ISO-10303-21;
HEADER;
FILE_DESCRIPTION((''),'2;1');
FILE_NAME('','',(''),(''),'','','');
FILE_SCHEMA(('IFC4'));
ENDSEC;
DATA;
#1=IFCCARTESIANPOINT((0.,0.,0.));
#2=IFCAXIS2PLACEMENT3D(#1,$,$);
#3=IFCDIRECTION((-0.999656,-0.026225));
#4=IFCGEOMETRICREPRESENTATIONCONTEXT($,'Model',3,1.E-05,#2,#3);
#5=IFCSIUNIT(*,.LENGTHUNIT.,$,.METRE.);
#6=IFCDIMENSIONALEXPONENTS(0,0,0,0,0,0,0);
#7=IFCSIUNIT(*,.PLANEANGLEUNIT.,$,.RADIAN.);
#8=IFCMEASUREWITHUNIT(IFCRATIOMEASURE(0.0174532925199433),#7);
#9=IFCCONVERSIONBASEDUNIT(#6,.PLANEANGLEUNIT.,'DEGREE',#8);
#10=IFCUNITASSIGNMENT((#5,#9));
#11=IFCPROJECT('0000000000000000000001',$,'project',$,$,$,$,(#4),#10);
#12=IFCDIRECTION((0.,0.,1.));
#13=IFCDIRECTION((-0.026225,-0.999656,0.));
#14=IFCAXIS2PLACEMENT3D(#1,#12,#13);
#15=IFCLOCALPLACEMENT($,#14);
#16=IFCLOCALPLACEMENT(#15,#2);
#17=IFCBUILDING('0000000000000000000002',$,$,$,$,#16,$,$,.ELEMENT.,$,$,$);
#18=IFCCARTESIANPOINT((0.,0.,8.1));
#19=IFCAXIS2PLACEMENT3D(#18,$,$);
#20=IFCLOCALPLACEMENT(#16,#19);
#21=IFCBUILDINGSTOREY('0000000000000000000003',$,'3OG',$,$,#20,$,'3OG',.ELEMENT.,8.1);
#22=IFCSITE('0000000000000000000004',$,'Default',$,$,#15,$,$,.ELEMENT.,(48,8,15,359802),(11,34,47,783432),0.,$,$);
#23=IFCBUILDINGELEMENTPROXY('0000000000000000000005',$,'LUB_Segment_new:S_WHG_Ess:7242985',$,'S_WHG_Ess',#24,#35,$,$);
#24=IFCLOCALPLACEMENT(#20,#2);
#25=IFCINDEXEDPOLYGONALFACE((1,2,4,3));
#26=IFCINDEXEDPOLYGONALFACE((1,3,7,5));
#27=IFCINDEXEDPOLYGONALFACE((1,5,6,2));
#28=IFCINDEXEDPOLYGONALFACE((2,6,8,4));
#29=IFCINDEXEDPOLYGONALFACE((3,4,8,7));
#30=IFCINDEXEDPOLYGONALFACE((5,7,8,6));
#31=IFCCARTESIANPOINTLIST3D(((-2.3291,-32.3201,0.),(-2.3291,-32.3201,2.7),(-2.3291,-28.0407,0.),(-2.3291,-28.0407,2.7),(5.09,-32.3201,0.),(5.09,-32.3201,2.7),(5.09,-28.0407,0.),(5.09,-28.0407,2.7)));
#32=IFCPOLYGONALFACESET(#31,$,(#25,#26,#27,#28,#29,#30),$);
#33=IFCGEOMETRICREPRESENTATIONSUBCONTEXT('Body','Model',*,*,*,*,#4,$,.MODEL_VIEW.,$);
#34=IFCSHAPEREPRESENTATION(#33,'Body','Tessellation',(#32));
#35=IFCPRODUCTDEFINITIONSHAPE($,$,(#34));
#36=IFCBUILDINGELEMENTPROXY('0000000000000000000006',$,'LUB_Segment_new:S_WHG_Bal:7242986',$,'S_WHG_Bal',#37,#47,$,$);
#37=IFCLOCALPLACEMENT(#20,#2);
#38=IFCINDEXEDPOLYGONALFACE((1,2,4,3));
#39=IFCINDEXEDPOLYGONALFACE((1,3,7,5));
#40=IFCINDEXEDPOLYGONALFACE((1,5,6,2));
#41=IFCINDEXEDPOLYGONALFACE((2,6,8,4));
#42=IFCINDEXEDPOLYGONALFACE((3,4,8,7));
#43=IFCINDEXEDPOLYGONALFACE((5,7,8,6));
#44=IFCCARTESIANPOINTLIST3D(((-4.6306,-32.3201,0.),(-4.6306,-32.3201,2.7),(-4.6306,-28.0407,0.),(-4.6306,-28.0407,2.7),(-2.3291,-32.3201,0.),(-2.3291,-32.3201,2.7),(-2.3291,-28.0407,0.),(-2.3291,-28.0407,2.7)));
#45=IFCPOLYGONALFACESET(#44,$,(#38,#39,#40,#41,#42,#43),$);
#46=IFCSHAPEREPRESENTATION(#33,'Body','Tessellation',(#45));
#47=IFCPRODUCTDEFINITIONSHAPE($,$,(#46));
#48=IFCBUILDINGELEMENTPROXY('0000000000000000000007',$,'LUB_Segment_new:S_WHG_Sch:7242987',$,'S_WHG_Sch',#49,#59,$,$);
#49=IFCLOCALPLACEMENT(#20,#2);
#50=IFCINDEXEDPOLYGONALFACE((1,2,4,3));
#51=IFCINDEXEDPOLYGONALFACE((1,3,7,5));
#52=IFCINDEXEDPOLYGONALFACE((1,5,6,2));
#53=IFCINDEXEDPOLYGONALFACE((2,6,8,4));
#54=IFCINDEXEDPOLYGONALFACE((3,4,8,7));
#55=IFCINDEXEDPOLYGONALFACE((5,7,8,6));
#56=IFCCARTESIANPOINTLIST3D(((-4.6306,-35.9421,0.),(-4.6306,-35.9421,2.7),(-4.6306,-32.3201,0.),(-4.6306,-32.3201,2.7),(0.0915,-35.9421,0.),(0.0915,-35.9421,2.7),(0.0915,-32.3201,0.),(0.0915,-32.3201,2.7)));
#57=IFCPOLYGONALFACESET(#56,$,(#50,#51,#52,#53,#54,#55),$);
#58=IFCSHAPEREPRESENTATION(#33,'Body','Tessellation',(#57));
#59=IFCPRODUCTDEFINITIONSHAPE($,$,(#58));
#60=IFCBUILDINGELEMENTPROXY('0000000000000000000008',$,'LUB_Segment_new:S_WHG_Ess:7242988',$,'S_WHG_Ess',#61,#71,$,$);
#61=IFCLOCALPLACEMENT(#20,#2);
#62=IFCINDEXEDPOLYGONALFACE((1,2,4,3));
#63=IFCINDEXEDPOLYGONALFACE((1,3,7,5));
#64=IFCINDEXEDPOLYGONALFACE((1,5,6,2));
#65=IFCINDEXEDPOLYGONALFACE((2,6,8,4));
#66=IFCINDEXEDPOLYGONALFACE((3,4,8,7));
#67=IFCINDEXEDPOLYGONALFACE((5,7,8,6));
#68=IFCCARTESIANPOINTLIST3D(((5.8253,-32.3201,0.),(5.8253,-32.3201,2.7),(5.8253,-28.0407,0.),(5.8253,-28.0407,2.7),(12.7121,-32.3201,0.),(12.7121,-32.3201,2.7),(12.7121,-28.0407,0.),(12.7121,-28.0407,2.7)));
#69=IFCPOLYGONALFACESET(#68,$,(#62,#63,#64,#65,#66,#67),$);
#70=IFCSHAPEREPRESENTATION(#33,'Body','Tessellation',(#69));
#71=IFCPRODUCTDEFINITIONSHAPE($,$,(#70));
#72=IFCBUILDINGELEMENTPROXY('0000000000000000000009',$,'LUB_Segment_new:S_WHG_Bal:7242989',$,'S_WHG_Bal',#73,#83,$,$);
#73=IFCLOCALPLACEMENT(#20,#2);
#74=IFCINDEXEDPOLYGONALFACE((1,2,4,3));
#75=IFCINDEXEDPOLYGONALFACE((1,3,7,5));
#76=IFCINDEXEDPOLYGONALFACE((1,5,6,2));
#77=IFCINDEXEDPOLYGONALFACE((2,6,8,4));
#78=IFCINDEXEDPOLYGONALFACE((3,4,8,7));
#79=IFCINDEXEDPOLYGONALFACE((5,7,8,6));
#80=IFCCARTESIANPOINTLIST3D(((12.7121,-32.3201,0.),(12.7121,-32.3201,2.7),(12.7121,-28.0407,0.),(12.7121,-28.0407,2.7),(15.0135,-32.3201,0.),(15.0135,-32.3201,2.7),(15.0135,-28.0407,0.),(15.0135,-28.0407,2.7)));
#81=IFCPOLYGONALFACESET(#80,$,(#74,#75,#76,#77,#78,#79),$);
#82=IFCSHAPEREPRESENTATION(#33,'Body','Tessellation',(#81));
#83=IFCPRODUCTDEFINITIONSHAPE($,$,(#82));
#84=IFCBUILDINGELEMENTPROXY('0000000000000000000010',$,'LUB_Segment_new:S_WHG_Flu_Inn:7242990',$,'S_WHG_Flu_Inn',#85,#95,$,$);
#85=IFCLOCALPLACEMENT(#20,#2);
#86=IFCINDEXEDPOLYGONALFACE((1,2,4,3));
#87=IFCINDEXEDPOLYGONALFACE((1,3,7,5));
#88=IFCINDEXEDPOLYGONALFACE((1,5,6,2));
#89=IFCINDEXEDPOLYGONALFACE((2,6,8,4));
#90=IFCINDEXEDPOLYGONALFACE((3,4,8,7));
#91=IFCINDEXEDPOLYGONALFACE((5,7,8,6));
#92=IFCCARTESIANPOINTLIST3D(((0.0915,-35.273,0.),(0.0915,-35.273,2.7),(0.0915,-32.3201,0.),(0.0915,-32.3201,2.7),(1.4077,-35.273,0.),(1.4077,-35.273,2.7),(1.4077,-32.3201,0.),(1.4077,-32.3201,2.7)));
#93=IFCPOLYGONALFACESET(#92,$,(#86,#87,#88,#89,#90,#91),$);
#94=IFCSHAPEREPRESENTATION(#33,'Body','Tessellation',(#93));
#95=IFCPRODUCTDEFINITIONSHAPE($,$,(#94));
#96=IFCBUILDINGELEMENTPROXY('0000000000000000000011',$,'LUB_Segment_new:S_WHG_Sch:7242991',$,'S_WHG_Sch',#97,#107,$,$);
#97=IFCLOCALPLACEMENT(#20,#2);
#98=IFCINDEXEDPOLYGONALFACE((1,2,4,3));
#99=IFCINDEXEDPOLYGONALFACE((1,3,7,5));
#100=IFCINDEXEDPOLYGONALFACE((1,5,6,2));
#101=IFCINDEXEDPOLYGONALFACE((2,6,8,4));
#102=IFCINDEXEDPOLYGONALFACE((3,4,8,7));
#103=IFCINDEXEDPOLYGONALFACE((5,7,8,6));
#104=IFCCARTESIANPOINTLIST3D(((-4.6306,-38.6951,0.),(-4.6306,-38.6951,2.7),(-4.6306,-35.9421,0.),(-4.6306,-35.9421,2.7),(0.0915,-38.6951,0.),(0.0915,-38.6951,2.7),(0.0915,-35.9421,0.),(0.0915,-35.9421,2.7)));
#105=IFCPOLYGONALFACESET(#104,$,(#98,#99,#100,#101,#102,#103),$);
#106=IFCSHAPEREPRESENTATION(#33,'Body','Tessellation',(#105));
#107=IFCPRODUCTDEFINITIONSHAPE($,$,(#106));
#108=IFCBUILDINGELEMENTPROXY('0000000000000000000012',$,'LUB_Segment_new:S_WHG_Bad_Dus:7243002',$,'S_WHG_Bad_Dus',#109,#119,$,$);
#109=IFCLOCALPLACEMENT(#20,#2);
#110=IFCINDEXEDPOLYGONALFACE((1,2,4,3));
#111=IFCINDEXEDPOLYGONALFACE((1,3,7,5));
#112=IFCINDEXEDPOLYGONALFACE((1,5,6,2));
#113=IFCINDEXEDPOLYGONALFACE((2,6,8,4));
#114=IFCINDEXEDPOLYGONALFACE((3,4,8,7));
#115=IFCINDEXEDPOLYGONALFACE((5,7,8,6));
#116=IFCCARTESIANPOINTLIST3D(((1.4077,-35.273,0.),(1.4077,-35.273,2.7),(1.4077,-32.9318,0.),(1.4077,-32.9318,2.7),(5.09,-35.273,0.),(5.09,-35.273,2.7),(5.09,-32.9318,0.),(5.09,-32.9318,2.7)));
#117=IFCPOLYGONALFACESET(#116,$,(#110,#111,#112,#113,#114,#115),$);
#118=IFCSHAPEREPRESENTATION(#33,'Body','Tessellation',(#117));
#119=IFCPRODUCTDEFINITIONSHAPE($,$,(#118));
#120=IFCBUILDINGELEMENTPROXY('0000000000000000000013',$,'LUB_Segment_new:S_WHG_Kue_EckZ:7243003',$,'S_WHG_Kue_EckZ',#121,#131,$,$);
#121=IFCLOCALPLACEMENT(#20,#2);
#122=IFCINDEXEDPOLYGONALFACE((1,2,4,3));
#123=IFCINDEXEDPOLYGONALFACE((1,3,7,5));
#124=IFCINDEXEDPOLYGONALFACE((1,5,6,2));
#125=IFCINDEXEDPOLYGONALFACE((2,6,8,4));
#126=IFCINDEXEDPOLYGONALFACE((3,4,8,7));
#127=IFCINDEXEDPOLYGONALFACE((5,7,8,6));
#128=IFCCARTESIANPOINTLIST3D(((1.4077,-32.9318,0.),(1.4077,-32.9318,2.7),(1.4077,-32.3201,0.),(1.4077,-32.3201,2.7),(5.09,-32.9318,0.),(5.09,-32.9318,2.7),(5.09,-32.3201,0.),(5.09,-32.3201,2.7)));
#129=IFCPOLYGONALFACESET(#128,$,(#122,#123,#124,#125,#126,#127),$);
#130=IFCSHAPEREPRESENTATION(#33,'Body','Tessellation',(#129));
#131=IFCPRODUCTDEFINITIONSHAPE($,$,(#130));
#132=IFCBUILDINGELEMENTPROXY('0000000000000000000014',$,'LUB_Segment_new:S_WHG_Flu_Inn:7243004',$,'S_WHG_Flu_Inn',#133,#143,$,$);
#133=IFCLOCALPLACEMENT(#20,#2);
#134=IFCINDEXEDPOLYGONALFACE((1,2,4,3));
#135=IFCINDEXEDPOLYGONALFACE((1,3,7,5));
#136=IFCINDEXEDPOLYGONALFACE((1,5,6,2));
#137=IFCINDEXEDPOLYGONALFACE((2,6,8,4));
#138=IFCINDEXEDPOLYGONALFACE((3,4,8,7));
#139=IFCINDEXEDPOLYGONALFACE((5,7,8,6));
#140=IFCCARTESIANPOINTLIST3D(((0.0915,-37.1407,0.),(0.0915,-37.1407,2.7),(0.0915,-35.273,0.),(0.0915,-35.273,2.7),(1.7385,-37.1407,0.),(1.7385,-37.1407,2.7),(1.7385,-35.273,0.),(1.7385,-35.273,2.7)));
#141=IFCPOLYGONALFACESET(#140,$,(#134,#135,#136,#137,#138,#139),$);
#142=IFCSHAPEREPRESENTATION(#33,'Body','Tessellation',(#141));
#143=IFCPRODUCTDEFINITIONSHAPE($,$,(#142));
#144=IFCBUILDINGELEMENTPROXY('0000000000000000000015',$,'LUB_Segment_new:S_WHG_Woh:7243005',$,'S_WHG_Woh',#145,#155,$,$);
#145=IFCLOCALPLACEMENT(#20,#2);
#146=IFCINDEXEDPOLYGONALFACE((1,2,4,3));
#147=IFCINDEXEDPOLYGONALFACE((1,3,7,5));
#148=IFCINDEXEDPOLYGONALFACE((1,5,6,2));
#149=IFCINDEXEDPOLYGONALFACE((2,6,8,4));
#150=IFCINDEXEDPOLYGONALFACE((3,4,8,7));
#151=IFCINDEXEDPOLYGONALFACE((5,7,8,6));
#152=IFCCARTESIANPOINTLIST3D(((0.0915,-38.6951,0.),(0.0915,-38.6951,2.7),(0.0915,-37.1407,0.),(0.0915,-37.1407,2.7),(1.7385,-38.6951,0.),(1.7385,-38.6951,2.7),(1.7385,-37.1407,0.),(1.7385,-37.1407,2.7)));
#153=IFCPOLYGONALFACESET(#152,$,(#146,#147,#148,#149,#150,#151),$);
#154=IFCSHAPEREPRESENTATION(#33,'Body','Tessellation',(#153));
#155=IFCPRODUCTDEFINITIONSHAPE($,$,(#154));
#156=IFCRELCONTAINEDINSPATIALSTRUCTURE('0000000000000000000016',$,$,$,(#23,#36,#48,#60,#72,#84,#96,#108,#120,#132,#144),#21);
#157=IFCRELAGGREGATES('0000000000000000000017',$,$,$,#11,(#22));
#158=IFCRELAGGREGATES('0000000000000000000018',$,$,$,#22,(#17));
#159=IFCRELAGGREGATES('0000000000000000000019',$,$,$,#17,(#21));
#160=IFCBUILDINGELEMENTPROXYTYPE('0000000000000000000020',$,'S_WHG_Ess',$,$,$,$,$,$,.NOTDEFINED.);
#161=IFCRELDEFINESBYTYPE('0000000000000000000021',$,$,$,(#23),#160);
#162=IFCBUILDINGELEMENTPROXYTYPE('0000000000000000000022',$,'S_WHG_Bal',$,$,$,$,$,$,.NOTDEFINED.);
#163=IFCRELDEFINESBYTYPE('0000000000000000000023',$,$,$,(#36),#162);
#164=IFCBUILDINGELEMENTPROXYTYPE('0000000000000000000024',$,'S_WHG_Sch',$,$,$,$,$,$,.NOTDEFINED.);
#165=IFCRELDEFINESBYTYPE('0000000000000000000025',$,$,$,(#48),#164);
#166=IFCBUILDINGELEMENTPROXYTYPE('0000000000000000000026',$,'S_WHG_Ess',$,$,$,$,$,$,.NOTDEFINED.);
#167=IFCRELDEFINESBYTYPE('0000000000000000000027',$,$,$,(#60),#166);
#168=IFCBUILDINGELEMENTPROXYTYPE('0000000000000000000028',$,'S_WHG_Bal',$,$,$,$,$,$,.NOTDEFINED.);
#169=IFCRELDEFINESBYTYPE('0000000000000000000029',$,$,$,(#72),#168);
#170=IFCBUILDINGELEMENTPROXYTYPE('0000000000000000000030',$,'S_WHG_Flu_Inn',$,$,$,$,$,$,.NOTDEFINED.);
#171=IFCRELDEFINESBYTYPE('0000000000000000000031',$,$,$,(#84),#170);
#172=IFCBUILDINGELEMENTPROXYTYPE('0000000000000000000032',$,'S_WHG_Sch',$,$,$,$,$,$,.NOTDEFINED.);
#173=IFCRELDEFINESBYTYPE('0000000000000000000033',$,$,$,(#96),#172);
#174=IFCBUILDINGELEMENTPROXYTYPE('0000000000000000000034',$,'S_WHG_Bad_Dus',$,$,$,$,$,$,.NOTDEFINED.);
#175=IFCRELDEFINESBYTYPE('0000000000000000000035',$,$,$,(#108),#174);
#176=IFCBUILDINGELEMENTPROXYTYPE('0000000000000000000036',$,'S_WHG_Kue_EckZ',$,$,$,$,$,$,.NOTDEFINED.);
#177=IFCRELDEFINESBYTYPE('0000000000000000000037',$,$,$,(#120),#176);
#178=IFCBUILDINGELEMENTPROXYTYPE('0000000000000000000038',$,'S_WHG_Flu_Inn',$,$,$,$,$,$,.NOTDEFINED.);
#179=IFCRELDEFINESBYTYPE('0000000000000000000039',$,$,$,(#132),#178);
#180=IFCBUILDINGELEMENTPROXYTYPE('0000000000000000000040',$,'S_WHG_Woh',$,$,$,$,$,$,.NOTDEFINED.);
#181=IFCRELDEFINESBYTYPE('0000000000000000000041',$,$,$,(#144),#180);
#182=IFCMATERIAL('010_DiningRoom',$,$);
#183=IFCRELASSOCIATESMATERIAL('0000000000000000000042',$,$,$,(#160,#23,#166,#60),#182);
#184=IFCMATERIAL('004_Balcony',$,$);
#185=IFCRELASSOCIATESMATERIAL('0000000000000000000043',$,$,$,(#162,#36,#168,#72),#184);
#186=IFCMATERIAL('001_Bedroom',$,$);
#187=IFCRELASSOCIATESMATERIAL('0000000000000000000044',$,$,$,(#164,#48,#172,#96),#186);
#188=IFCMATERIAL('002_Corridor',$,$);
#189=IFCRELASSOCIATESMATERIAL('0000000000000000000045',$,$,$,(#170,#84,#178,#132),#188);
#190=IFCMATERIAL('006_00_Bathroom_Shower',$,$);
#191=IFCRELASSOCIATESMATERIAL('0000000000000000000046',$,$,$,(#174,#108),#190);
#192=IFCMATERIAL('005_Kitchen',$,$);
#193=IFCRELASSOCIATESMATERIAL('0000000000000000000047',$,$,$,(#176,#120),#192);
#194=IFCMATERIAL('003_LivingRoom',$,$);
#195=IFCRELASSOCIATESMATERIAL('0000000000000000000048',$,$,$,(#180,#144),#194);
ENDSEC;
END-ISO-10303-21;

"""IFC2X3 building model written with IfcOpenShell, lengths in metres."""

from ifc_helpers import new_model, entity, si_unit, converted_unit, direction, frame, origin, origin_2d_with_axis, place, context, subcontext, project, spatial, rectangle, extrude, source, transform, mapped, material, type_object, type_shapes, element, save


model = new_model("IFC2X3")

# Units and contexts
model_context = context("Model", 3, precision=1e-05, world=origin(), true_north=direction((-0.999656, -0.026225)))
body_context = subcontext(model_context, "Body", "Model", "MODEL_VIEW")
ifc_project = project(units=[si_unit("LENGTHUNIT", "METRE"), converted_unit("PLANEANGLEUNIT", "DEGREE", entity("IfcRatioMeasure", 0.0174532925199433), si_unit("PLANEANGLEUNIT", "RADIAN"), dimensions=[0, 0, 0, 0, 0, 0, 0])], contexts=[model_context])

# Site, building, storey
site_placement = place(None, frame((0.0, 0.0, 0.0), z_axis=(0.0, 0.0, 1.0), x_axis=(-0.026225, -0.999656, 0.0)))
site = spatial("IfcSite", under=ifc_project, at=site_placement, Name="Default", CompositionType="ELEMENT", RefLatitude=(48, 8, 15, 359802), RefLongitude=(11, 34, 47, 783432), RefElevation=0.0)
building_placement = place(site_placement, origin())
building = spatial("IfcBuilding", under=site, at=building_placement, CompositionType="ELEMENT")
storey_placement = place(building_placement, frame((0.0, 0.0, 8.1)))
storey = spatial("IfcBuildingStorey", under=building, at=storey_placement, Name="3OG", LongName="3OG", CompositionType="ELEMENT", Elevation=8.1)

# Building element proxies
ifc_material_1 = material(Name="010_DiningRoom")
building_element_proxy_type_1 = type_object("IfcBuildingElementProxyType", Name="S_WHG_Ess", PredefinedType="NOTDEFINED", material=ifc_material_1)
shared_shape_1 = source(origin(), body_context, "Body", "SweptSolid", [
    extrude(rectangle(XDim=7.4191, YDim=4.2794, at=origin_2d_with_axis()), frame((0.0, 0.0, 0.0), z_axis=(0.0, 0.0, 1.0), x_axis=(-1.0, 0.0, 0.0)), (0.0, 0.0, 1.0), 2.7),
])
type_shapes(building_element_proxy_type_1, [shared_shape_1])
proxy_1_placement = place(storey_placement, frame((1.3805, -30.1804, 0.0)))
element("IfcBuildingElementProxy", 1, at=proxy_1_placement, inside=storey, type_object=building_element_proxy_type_1, material=ifc_material_1, Name="LUB_Segment_new:S_WHG_Ess:7242985", ObjectType="S_WHG_Ess", context=body_context, shape_type="MappedRepresentation", body=[
    mapped(shared_shape_1, transform((0.0, 0.0, 0.0), scale=1.0)),
])
ifc_material_2 = material(Name="004_Balcony")
building_element_proxy_type_2 = type_object("IfcBuildingElementProxyType", Name="S_WHG_Bal", PredefinedType="NOTDEFINED", material=ifc_material_2)
shared_shape_2 = source(origin(), body_context, "Body", "SweptSolid", [
    extrude(rectangle(XDim=2.3015, YDim=4.2794, at=origin_2d_with_axis()), frame((0.0, 0.0, 0.0), z_axis=(0.0, 0.0, 1.0), x_axis=(-1.0, 0.0, 0.0)), (0.0, 0.0, 1.0), 2.7),
])
type_shapes(building_element_proxy_type_2, [shared_shape_2])
proxy_2_placement = place(storey_placement, frame((-3.4798, -30.1804, 0.0)))
element("IfcBuildingElementProxy", 2, at=proxy_2_placement, inside=storey, type_object=building_element_proxy_type_2, material=ifc_material_2, Name="LUB_Segment_new:S_WHG_Bal:7242986", ObjectType="S_WHG_Bal", context=body_context, shape_type="MappedRepresentation", body=[
    mapped(shared_shape_2, transform((0.0, 0.0, 0.0), scale=1.0)),
])
ifc_material_3 = material(Name="001_Bedroom")
building_element_proxy_type_3 = type_object("IfcBuildingElementProxyType", Name="S_WHG_Sch", PredefinedType="NOTDEFINED", material=ifc_material_3)
shared_shape_3 = source(origin(), body_context, "Body", "SweptSolid", [
    extrude(rectangle(XDim=4.7221, YDim=3.6221, at=origin_2d_with_axis()), frame((0.0, 0.0, 0.0), z_axis=(0.0, 0.0, 1.0), x_axis=(-1.0, 0.0, 0.0)), (0.0, 0.0, 1.0), 2.7),
])
type_shapes(building_element_proxy_type_3, [shared_shape_3])
proxy_3_placement = place(storey_placement, frame((-2.2695, -34.1311, 0.0)))
element("IfcBuildingElementProxy", 3, at=proxy_3_placement, inside=storey, type_object=building_element_proxy_type_3, material=ifc_material_3, Name="LUB_Segment_new:S_WHG_Sch:7242987", ObjectType="S_WHG_Sch", context=body_context, shape_type="MappedRepresentation", body=[
    mapped(shared_shape_3, transform((0.0, 0.0, 0.0), scale=1.0)),
])
building_element_proxy_type_4 = type_object("IfcBuildingElementProxyType", Name="S_WHG_Ess", PredefinedType="NOTDEFINED", material=ifc_material_1)
shared_shape_4 = source(origin(), body_context, "Body", "SweptSolid", [
    extrude(rectangle(XDim=6.8868, YDim=4.2794, at=origin_2d_with_axis()), frame((0.0, 0.0, 0.0), z_axis=(0.0, 0.0, 1.0), x_axis=(-1.0, 0.0, 0.0)), (0.0, 0.0, 1.0), 2.7),
])
type_shapes(building_element_proxy_type_4, [shared_shape_4])
proxy_4_placement = place(storey_placement, frame((9.2687, -30.1804, 0.0)))
element("IfcBuildingElementProxy", 4, at=proxy_4_placement, inside=storey, type_object=building_element_proxy_type_4, material=ifc_material_1, Name="LUB_Segment_new:S_WHG_Ess:7242988", ObjectType="S_WHG_Ess", context=body_context, shape_type="MappedRepresentation", body=[
    mapped(shared_shape_4, transform((0.0, 0.0, 0.0), scale=1.0)),
])
building_element_proxy_type_5 = type_object("IfcBuildingElementProxyType", Name="S_WHG_Bal", PredefinedType="NOTDEFINED", material=ifc_material_2)
shared_shape_5 = source(origin(), body_context, "Body", "SweptSolid", [
    extrude(rectangle(XDim=4.2794, YDim=2.3015, at=origin_2d_with_axis()), frame((0.0, 0.0, 0.0), z_axis=(0.0, 0.0, 1.0), x_axis=(0.0, 1.0, 0.0)), (0.0, 0.0, 1.0), 2.7),
])
type_shapes(building_element_proxy_type_5, [shared_shape_5])
proxy_5_placement = place(storey_placement, frame((13.8628, -30.1804, 0.0), z_axis=(0.0, 0.0, 1.0), x_axis=(-1.0, 0.0, 0.0)))
element("IfcBuildingElementProxy", 5, at=proxy_5_placement, inside=storey, type_object=building_element_proxy_type_5, material=ifc_material_2, Name="LUB_Segment_new:S_WHG_Bal:7242989", ObjectType="S_WHG_Bal", context=body_context, shape_type="MappedRepresentation", body=[
    mapped(shared_shape_5, transform((0.0, 0.0, 0.0), scale=1.0)),
])
ifc_material_4 = material(Name="002_Corridor")
building_element_proxy_type_6 = type_object("IfcBuildingElementProxyType", Name="S_WHG_Flu_Inn", PredefinedType="NOTDEFINED", material=ifc_material_4)
shared_shape_6 = source(origin(), body_context, "Body", "SweptSolid", [
    extrude(rectangle(XDim=1.3162, YDim=2.9529, at=origin_2d_with_axis()), frame((0.0, 0.0, 0.0), z_axis=(0.0, 0.0, 1.0), x_axis=(-1.0, 0.0, 0.0)), (0.0, 0.0, 1.0), 2.7),
])
type_shapes(building_element_proxy_type_6, [shared_shape_6])
proxy_6_placement = place(storey_placement, frame((0.7496, -33.7966, 0.0)))
element("IfcBuildingElementProxy", 6, at=proxy_6_placement, inside=storey, type_object=building_element_proxy_type_6, material=ifc_material_4, Name="LUB_Segment_new:S_WHG_Flu_Inn:7242990", ObjectType="S_WHG_Flu_Inn", context=body_context, shape_type="MappedRepresentation", body=[
    mapped(shared_shape_6, transform((0.0, 0.0, 0.0), scale=1.0)),
])
building_element_proxy_type_7 = type_object("IfcBuildingElementProxyType", Name="S_WHG_Sch", PredefinedType="NOTDEFINED", material=ifc_material_3)
shared_shape_7 = source(origin(), body_context, "Body", "SweptSolid", [
    extrude(rectangle(XDim=4.7221, YDim=2.7529, at=origin_2d_with_axis()), frame((0.0, 0.0, 0.0), z_axis=(0.0, 0.0, 1.0), x_axis=(-1.0, 0.0, 0.0)), (0.0, 0.0, 1.0), 2.7),
])
type_shapes(building_element_proxy_type_7, [shared_shape_7])
proxy_7_placement = place(storey_placement, frame((-2.2695, -37.3186, 0.0)))
element("IfcBuildingElementProxy", 7, at=proxy_7_placement, inside=storey, type_object=building_element_proxy_type_7, material=ifc_material_3, Name="LUB_Segment_new:S_WHG_Sch:7242991", ObjectType="S_WHG_Sch", context=body_context, shape_type="MappedRepresentation", body=[
    mapped(shared_shape_7, transform((0.0, 0.0, 0.0), scale=1.0)),
])
ifc_material_5 = material(Name="006_00_Bathroom_Shower")
building_element_proxy_type_8 = type_object("IfcBuildingElementProxyType", Name="S_WHG_Bad_Dus", PredefinedType="NOTDEFINED", material=ifc_material_5)
shared_shape_8 = source(origin(), body_context, "Body", "SweptSolid", [
    extrude(rectangle(XDim=2.3412, YDim=3.6824, at=origin_2d_with_axis()), frame((0.0, 0.0, 0.0), z_axis=(0.0, 0.0, 1.0), x_axis=(0.0, 1.0, 0.0)), (0.0, 0.0, 1.0), 2.7),
])
type_shapes(building_element_proxy_type_8, [shared_shape_8])
proxy_8_placement = place(storey_placement, frame((3.2488, -34.1024, 0.0)))
element("IfcBuildingElementProxy", 8, at=proxy_8_placement, inside=storey, type_object=building_element_proxy_type_8, material=ifc_material_5, Name="LUB_Segment_new:S_WHG_Bad_Dus:7243002", ObjectType="S_WHG_Bad_Dus", context=body_context, shape_type="MappedRepresentation", body=[
    mapped(shared_shape_8, transform((0.0, 0.0, 0.0), scale=1.0)),
])
ifc_material_6 = material(Name="005_Kitchen")
building_element_proxy_type_9 = type_object("IfcBuildingElementProxyType", Name="S_WHG_Kue_EckZ", PredefinedType="NOTDEFINED", material=ifc_material_6)
shared_shape_9 = source(origin(), body_context, "Body", "SweptSolid", [
    extrude(rectangle(XDim=0.6118, YDim=3.6824, at=origin_2d_with_axis()), frame((0.0, 0.0, 0.0), z_axis=(0.0, 0.0, 1.0), x_axis=(0.0, 1.0, 0.0)), (0.0, 0.0, 1.0), 2.7),
])
type_shapes(building_element_proxy_type_9, [shared_shape_9])
proxy_9_placement = place(storey_placement, frame((3.2488, -32.626, 0.0)))
element("IfcBuildingElementProxy", 9, at=proxy_9_placement, inside=storey, type_object=building_element_proxy_type_9, material=ifc_material_6, Name="LUB_Segment_new:S_WHG_Kue_EckZ:7243003", ObjectType="S_WHG_Kue_EckZ", context=body_context, shape_type="MappedRepresentation", body=[
    mapped(shared_shape_9, transform((0.0, 0.0, 0.0), scale=1.0)),
])
building_element_proxy_type_10 = type_object("IfcBuildingElementProxyType", Name="S_WHG_Flu_Inn", PredefinedType="NOTDEFINED", material=ifc_material_4)
shared_shape_10 = source(origin(), body_context, "Body", "SweptSolid", [
    extrude(rectangle(XDim=1.6471, YDim=1.8676, at=origin_2d_with_axis()), frame((0.0, 0.0, 0.0), z_axis=(0.0, 0.0, 1.0), x_axis=(-1.0, 0.0, 0.0)), (0.0, 0.0, 1.0), 2.7),
])
type_shapes(building_element_proxy_type_10, [shared_shape_10])
proxy_10_placement = place(storey_placement, frame((0.915, -36.2068, 0.0)))
element("IfcBuildingElementProxy", 10, at=proxy_10_placement, inside=storey, type_object=building_element_proxy_type_10, material=ifc_material_4, Name="LUB_Segment_new:S_WHG_Flu_Inn:7243004", ObjectType="S_WHG_Flu_Inn", context=body_context, shape_type="MappedRepresentation", body=[
    mapped(shared_shape_10, transform((0.0, 0.0, 0.0), scale=1.0)),
])
ifc_material_7 = material(Name="003_LivingRoom")
building_element_proxy_type_11 = type_object("IfcBuildingElementProxyType", Name="S_WHG_Woh", PredefinedType="NOTDEFINED", material=ifc_material_7)
shared_shape_11 = source(origin(), body_context, "Body", "SweptSolid", [
    extrude(rectangle(XDim=1.6471, YDim=1.5544, at=origin_2d_with_axis()), frame((0.0, 0.0, 0.0), z_axis=(0.0, 0.0, 1.0), x_axis=(-1.0, 0.0, 0.0)), (0.0, 0.0, 1.0), 2.7),
])
type_shapes(building_element_proxy_type_11, [shared_shape_11])
proxy_11_placement = place(storey_placement, frame((0.915, -37.9179, 0.0)))
element("IfcBuildingElementProxy", 11, at=proxy_11_placement, inside=storey, type_object=building_element_proxy_type_11, material=ifc_material_7, Name="LUB_Segment_new:S_WHG_Woh:7243005", ObjectType="S_WHG_Woh", context=body_context, shape_type="MappedRepresentation", body=[
    mapped(shared_shape_11, transform((0.0, 0.0, 0.0), scale=1.0)),
])

save(model, "model.ifc")
